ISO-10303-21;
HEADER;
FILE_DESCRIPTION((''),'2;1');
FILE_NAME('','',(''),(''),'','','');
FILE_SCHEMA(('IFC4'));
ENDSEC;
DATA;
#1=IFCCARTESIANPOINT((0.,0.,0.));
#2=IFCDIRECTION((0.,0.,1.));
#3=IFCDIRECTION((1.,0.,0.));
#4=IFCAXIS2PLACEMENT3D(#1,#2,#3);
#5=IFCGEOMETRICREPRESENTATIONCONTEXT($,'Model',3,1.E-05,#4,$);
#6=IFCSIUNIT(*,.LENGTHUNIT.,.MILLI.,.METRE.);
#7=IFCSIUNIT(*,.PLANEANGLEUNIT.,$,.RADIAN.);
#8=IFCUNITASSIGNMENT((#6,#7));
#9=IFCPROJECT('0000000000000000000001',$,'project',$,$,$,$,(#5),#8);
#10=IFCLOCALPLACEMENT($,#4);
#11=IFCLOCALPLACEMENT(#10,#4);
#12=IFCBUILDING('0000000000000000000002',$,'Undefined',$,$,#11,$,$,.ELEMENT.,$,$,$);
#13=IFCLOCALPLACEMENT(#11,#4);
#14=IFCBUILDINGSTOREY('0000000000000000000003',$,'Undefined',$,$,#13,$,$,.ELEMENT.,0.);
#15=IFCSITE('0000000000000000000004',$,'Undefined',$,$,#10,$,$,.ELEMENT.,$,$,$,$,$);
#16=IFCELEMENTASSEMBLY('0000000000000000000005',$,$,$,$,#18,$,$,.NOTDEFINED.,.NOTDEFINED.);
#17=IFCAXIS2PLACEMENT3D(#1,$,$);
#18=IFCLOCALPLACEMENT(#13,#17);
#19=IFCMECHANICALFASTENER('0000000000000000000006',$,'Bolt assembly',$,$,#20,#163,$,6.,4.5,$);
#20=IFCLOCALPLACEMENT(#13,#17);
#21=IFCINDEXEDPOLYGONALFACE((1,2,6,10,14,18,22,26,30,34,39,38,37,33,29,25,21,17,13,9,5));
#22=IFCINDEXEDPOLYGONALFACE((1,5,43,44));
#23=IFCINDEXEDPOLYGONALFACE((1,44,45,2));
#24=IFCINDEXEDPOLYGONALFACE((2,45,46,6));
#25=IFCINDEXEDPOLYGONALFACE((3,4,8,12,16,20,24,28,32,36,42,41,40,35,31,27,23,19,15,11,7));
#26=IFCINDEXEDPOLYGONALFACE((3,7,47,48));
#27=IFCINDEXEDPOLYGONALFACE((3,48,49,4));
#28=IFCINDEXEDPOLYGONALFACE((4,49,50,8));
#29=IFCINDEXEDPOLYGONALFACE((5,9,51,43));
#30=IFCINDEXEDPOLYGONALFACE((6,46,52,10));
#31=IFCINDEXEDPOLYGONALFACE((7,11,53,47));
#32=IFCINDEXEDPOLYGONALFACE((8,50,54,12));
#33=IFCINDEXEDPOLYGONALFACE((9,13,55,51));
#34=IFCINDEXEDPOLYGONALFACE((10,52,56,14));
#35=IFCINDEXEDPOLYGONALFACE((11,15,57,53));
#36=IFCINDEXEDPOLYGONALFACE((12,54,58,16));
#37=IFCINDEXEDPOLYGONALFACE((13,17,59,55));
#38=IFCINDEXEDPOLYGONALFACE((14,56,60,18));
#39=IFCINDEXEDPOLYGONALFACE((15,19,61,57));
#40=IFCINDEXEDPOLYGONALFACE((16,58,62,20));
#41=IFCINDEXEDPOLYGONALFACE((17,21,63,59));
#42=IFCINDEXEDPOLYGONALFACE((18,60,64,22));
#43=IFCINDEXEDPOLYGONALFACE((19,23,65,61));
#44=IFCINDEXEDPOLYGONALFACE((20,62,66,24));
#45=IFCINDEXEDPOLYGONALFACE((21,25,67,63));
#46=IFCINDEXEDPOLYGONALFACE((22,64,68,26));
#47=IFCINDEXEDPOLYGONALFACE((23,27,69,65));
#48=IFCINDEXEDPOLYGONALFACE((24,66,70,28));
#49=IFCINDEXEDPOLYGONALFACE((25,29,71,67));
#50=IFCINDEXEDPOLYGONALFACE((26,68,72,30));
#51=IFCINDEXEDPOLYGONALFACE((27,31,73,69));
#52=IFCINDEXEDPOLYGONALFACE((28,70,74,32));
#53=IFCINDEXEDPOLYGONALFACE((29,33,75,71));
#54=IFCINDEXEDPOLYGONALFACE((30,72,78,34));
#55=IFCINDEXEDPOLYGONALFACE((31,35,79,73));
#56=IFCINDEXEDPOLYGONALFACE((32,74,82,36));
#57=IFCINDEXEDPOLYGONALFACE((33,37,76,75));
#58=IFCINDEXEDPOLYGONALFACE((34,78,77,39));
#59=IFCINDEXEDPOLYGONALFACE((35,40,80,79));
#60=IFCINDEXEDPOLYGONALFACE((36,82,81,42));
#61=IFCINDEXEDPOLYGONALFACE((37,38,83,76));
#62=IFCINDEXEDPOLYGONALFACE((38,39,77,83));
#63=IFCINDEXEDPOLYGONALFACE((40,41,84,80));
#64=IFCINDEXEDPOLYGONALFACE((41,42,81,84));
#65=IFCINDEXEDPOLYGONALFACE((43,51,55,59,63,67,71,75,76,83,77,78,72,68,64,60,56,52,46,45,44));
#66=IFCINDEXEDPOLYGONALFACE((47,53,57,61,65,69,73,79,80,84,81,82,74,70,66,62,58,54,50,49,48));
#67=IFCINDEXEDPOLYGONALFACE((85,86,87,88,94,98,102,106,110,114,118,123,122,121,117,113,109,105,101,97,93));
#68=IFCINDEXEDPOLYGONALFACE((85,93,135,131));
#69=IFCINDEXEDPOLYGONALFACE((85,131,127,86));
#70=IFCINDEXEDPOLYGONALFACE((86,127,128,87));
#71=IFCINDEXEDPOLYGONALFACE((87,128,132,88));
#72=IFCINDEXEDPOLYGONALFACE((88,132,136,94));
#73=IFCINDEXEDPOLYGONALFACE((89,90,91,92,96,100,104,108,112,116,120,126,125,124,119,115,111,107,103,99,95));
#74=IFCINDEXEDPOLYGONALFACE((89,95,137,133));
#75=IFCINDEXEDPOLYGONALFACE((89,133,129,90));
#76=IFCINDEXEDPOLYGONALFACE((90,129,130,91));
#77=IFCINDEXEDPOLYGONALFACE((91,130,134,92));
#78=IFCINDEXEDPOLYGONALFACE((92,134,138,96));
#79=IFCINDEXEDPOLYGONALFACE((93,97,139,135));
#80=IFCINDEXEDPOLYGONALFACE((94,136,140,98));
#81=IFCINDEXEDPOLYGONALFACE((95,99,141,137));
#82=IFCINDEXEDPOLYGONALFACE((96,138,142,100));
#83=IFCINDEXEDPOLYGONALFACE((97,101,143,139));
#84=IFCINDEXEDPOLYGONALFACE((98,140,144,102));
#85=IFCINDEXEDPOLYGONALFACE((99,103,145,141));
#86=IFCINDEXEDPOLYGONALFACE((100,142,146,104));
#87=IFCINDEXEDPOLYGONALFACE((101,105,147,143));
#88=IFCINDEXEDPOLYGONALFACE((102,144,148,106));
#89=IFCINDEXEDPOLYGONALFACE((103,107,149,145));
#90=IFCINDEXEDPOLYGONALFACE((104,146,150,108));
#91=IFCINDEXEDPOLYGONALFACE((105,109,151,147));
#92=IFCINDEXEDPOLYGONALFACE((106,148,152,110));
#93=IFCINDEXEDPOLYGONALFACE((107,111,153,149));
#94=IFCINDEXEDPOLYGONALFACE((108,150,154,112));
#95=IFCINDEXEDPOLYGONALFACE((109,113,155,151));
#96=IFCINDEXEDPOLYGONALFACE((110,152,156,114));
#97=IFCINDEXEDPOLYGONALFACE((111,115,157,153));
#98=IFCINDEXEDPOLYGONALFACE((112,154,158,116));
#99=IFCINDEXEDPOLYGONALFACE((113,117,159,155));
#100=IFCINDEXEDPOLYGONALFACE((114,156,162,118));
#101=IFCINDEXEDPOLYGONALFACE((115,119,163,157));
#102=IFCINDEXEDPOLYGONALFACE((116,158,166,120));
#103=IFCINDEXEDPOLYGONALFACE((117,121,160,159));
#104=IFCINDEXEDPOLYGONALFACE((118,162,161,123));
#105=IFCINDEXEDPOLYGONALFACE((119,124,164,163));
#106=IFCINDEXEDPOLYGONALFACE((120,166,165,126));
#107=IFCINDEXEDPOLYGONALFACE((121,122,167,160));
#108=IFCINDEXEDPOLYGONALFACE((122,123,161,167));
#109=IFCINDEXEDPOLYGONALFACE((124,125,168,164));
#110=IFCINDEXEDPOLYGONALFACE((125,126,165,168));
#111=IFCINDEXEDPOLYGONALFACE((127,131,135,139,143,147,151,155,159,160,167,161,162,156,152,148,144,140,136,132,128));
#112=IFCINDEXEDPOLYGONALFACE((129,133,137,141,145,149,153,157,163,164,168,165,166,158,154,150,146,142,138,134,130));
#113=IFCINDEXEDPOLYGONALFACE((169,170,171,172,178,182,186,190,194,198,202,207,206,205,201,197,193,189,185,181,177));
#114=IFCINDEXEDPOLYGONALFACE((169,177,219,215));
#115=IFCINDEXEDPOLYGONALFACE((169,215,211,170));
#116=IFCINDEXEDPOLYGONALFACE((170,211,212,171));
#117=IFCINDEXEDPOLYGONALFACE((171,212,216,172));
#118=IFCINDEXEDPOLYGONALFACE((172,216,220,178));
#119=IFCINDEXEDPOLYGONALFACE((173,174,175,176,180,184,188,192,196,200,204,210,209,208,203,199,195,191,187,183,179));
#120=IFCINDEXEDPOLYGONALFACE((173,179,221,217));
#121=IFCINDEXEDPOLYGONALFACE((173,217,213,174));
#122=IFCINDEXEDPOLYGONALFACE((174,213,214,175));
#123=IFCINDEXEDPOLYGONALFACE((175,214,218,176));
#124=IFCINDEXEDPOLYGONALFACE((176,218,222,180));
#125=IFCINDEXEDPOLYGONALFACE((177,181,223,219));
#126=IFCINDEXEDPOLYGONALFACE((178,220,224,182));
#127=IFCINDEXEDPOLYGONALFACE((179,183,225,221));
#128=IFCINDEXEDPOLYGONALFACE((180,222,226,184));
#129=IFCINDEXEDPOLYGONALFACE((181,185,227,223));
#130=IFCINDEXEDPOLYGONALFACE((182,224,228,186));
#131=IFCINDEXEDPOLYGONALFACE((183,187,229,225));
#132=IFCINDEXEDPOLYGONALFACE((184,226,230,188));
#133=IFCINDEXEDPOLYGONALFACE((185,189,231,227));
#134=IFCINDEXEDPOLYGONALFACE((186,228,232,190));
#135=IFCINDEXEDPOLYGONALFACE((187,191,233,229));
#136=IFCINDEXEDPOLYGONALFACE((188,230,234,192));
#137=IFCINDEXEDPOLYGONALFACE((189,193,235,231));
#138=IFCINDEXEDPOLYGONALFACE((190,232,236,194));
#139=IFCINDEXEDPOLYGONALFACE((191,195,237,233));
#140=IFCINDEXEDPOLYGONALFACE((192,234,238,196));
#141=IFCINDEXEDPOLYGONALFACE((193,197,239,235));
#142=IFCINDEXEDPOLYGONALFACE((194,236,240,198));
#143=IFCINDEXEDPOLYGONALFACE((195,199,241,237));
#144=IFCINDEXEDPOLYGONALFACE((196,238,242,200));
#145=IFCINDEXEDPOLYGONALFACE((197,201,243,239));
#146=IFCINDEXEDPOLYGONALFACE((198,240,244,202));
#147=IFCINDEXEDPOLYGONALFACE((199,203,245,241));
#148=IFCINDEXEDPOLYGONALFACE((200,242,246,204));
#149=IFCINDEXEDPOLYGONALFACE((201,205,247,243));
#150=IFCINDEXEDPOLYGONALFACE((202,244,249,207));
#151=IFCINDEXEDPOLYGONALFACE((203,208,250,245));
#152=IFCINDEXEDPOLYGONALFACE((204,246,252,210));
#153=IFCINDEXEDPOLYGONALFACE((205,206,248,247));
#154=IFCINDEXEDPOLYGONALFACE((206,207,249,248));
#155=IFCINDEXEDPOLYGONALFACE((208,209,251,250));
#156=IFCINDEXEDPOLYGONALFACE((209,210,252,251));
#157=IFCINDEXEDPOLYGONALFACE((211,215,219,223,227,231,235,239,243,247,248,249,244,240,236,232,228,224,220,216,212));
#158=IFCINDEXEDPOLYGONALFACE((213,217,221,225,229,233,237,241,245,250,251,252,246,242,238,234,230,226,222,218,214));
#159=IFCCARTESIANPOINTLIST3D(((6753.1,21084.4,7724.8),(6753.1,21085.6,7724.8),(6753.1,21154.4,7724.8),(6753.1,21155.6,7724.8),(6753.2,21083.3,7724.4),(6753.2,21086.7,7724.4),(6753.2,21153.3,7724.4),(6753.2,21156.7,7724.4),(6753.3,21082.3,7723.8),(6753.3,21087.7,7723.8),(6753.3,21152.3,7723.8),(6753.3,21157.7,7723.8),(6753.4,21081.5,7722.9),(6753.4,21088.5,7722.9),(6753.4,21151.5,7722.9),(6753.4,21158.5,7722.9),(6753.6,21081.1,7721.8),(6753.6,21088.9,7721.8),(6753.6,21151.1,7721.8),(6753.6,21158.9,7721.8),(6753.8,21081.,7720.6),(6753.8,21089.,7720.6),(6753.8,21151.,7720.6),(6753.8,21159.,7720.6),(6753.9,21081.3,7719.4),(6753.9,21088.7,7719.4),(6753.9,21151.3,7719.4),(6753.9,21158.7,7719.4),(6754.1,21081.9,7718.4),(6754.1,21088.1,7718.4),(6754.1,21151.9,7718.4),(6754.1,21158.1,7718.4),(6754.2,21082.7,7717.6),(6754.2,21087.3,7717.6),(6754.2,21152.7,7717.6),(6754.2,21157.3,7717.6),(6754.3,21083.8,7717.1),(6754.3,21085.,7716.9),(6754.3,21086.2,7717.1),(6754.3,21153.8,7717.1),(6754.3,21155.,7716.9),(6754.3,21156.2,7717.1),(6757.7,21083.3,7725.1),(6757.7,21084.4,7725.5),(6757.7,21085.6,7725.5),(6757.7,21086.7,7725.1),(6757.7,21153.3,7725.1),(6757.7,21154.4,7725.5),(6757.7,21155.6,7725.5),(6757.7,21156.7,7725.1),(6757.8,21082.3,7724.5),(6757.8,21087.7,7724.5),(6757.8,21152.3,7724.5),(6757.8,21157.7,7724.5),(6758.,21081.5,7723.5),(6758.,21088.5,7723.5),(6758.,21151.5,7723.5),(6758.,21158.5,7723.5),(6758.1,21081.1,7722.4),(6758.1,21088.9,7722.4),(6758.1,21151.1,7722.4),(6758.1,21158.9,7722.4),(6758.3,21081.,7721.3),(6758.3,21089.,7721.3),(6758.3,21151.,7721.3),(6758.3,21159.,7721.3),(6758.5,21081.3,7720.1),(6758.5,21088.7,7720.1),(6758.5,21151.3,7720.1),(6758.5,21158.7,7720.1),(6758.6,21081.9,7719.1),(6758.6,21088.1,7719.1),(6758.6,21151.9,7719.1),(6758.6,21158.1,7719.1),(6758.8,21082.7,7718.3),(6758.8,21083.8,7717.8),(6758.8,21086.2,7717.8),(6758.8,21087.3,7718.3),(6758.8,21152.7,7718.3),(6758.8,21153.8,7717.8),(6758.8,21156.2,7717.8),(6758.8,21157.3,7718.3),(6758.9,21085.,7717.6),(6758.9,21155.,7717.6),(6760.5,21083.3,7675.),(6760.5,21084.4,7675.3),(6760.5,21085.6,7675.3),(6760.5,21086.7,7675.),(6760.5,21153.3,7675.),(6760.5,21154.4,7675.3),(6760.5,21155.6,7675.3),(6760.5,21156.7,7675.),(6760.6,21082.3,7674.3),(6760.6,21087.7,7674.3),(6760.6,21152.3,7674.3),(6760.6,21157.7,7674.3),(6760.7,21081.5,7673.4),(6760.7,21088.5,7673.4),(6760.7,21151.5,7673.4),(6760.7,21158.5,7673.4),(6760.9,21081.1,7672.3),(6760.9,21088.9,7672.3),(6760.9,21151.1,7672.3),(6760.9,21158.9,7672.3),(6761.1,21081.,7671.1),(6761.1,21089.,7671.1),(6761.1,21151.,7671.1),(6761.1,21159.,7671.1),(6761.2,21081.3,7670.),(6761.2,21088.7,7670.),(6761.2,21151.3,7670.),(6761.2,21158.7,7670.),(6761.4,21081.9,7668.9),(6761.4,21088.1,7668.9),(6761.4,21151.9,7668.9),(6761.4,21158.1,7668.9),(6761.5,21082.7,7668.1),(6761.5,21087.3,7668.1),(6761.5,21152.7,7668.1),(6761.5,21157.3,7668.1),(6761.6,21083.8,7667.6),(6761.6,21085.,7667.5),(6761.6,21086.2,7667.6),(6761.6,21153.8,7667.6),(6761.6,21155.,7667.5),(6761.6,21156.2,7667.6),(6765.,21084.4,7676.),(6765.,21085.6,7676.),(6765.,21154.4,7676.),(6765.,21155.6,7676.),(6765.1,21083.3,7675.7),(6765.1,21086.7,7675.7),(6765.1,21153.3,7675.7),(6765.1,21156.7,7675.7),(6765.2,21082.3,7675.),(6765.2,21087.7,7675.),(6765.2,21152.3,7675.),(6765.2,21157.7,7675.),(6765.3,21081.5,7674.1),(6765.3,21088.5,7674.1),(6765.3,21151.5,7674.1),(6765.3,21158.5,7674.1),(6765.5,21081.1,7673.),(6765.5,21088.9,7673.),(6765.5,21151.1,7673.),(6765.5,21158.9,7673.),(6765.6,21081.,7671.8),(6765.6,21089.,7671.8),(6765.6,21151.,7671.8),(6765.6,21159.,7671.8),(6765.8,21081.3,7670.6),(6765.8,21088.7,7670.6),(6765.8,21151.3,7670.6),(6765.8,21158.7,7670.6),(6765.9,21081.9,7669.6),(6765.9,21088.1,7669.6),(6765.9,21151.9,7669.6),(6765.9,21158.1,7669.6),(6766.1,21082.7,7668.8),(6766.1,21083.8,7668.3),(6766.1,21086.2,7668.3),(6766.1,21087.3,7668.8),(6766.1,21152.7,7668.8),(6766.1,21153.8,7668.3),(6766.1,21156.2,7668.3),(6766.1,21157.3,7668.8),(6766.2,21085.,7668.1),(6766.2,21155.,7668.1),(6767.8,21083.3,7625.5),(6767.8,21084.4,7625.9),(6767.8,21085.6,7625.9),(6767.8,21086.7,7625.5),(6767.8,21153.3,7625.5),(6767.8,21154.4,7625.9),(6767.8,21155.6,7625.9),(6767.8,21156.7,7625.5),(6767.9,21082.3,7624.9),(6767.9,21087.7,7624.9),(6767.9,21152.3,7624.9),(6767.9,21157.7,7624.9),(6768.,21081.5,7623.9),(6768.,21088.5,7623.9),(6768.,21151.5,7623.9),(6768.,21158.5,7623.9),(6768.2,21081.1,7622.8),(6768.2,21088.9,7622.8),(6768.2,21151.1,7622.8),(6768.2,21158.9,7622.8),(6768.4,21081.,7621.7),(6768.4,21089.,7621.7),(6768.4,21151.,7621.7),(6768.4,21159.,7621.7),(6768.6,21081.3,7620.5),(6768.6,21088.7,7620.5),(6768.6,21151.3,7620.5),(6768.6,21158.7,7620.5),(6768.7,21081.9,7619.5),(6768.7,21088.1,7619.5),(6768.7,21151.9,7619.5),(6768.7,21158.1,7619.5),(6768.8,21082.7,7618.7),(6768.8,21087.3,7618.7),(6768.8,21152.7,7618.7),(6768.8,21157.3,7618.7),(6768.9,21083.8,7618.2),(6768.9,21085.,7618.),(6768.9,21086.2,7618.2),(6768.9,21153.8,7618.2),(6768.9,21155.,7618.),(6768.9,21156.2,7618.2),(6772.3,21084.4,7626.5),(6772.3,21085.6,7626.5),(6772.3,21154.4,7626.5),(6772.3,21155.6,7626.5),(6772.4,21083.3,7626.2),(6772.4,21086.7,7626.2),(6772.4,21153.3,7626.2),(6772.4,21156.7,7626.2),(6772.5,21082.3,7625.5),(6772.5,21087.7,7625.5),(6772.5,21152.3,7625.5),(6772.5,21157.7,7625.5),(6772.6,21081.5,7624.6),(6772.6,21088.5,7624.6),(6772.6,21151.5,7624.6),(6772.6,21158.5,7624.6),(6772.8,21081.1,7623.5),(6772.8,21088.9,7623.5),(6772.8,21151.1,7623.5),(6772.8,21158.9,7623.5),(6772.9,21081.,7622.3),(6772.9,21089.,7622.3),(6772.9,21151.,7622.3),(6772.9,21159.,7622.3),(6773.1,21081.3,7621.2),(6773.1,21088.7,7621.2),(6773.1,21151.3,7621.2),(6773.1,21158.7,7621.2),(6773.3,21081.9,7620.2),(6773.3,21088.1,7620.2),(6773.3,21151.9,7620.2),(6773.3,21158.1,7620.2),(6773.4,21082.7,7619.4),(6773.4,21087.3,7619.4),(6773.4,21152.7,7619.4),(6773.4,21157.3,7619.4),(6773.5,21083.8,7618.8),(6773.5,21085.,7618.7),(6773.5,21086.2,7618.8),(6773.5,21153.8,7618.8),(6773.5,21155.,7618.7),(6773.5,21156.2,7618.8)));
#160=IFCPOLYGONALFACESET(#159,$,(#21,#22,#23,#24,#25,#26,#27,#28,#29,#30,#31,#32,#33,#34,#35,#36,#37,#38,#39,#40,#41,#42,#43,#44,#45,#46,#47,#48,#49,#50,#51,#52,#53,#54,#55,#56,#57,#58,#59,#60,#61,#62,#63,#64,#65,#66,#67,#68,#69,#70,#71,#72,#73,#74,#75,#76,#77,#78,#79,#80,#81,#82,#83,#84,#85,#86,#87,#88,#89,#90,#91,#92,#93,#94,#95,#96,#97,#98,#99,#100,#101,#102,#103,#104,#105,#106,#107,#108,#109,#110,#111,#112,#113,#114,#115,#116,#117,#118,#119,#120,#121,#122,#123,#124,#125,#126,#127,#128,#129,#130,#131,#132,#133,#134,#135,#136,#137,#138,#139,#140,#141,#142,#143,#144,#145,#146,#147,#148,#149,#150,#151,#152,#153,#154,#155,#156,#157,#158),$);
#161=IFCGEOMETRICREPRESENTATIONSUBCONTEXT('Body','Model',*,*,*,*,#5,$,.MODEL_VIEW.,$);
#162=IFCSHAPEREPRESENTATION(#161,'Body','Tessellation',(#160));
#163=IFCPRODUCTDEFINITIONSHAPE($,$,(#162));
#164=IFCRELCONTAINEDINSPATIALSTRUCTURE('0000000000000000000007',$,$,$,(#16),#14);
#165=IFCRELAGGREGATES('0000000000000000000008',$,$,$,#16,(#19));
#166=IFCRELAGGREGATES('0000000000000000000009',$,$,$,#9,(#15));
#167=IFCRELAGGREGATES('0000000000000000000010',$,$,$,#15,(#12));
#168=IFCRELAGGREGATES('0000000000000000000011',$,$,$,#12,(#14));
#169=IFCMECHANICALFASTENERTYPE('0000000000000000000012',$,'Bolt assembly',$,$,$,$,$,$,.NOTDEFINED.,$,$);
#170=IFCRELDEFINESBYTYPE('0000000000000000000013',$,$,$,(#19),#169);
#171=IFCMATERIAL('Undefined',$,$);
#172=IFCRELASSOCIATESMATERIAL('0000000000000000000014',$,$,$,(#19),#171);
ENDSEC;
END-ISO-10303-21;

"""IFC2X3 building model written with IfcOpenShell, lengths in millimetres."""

from ifc_helpers import new_model, si_unit, frame, origin_with_axes, origin_2d_with_axis, place, context, subcontext, project, spatial, circle, extrude, source, transform, mapped, material, type_object, element, aggregate, save


model = new_model("IFC2X3")

# Units and contexts
model_context = context("Model", 3, precision=1e-05, world=origin_with_axes())
body_context = subcontext(model_context, "Body", "Model", "MODEL_VIEW")
ifc_project = project(units=[si_unit("LENGTHUNIT", "METRE", prefix="MILLI"), si_unit("PLANEANGLEUNIT", "RADIAN")], contexts=[model_context])

# Site, building, storey
site_placement = place(None, origin_with_axes())
site = spatial("IfcSite", under=ifc_project, at=site_placement, Name="Undefined", CompositionType="ELEMENT")
building_placement = place(site_placement, origin_with_axes())
building = spatial("IfcBuilding", under=site, at=building_placement, Name="Undefined", CompositionType="ELEMENT")
storey_placement = place(building_placement, origin_with_axes())
storey = spatial("IfcBuildingStorey", under=building, at=storey_placement, Name="Undefined", CompositionType="ELEMENT", Elevation=0.0)

# Element assembly
assembly_1_placement = place(storey_placement, origin_with_axes())
assembly_1 = element("IfcElementAssembly", 1, at=assembly_1_placement, inside=storey, AssemblyPlace="NOTDEFINED", PredefinedType="NOTDEFINED")

# Mechanical fastener
ifc_material_1 = material(Name="Undefined")
mechanical_fastener_type = type_object("IfcMechanicalFastenerType", Name="Bolt assembly")
shared_shape_1 = source(origin_with_axes(), body_context, "Body", "SweptSolid", [
    extrude(circle(Radius=4.0, at=origin_2d_with_axis()), frame((0.0, 0.0, 0.0), z_axis=(0.0, 1.0, 0.0), x_axis=(1.0, 0.0, 0.0)), (0.0, 0.0, 1.0), 4.6),
])
mechanical_fastener_1_placement = place(assembly_1_placement, frame((6753.7, 21120.0, 7720.9), z_axis=(0.0, -1.0, 0.0), x_axis=(0.146203, 0.0, -0.989255)))
mechanical_fastener_1 = element("IfcMechanicalFastener", 2, at=mechanical_fastener_1_placement, type_object=mechanical_fastener_type, material=ifc_material_1, Name="Bolt assembly", NominalDiameter=6.0, NominalLength=4.5, context=body_context, shape_type="MappedRepresentation", body=[
    mapped(shared_shape_1, transform((0.0, 0.0, -35.0))),
    mapped(shared_shape_1, transform((50.0, 0.0, -35.0))),
    mapped(shared_shape_1, transform((100.0, 0.0, -35.0))),
    mapped(shared_shape_1, transform((0.0, 0.0, 35.0))),
    mapped(shared_shape_1, transform((50.0, 0.0, 35.0))),
    mapped(shared_shape_1, transform((100.0, 0.0, 35.0))),
])

aggregate(assembly_1, [mechanical_fastener_1])

save(model, "model.ifc")
